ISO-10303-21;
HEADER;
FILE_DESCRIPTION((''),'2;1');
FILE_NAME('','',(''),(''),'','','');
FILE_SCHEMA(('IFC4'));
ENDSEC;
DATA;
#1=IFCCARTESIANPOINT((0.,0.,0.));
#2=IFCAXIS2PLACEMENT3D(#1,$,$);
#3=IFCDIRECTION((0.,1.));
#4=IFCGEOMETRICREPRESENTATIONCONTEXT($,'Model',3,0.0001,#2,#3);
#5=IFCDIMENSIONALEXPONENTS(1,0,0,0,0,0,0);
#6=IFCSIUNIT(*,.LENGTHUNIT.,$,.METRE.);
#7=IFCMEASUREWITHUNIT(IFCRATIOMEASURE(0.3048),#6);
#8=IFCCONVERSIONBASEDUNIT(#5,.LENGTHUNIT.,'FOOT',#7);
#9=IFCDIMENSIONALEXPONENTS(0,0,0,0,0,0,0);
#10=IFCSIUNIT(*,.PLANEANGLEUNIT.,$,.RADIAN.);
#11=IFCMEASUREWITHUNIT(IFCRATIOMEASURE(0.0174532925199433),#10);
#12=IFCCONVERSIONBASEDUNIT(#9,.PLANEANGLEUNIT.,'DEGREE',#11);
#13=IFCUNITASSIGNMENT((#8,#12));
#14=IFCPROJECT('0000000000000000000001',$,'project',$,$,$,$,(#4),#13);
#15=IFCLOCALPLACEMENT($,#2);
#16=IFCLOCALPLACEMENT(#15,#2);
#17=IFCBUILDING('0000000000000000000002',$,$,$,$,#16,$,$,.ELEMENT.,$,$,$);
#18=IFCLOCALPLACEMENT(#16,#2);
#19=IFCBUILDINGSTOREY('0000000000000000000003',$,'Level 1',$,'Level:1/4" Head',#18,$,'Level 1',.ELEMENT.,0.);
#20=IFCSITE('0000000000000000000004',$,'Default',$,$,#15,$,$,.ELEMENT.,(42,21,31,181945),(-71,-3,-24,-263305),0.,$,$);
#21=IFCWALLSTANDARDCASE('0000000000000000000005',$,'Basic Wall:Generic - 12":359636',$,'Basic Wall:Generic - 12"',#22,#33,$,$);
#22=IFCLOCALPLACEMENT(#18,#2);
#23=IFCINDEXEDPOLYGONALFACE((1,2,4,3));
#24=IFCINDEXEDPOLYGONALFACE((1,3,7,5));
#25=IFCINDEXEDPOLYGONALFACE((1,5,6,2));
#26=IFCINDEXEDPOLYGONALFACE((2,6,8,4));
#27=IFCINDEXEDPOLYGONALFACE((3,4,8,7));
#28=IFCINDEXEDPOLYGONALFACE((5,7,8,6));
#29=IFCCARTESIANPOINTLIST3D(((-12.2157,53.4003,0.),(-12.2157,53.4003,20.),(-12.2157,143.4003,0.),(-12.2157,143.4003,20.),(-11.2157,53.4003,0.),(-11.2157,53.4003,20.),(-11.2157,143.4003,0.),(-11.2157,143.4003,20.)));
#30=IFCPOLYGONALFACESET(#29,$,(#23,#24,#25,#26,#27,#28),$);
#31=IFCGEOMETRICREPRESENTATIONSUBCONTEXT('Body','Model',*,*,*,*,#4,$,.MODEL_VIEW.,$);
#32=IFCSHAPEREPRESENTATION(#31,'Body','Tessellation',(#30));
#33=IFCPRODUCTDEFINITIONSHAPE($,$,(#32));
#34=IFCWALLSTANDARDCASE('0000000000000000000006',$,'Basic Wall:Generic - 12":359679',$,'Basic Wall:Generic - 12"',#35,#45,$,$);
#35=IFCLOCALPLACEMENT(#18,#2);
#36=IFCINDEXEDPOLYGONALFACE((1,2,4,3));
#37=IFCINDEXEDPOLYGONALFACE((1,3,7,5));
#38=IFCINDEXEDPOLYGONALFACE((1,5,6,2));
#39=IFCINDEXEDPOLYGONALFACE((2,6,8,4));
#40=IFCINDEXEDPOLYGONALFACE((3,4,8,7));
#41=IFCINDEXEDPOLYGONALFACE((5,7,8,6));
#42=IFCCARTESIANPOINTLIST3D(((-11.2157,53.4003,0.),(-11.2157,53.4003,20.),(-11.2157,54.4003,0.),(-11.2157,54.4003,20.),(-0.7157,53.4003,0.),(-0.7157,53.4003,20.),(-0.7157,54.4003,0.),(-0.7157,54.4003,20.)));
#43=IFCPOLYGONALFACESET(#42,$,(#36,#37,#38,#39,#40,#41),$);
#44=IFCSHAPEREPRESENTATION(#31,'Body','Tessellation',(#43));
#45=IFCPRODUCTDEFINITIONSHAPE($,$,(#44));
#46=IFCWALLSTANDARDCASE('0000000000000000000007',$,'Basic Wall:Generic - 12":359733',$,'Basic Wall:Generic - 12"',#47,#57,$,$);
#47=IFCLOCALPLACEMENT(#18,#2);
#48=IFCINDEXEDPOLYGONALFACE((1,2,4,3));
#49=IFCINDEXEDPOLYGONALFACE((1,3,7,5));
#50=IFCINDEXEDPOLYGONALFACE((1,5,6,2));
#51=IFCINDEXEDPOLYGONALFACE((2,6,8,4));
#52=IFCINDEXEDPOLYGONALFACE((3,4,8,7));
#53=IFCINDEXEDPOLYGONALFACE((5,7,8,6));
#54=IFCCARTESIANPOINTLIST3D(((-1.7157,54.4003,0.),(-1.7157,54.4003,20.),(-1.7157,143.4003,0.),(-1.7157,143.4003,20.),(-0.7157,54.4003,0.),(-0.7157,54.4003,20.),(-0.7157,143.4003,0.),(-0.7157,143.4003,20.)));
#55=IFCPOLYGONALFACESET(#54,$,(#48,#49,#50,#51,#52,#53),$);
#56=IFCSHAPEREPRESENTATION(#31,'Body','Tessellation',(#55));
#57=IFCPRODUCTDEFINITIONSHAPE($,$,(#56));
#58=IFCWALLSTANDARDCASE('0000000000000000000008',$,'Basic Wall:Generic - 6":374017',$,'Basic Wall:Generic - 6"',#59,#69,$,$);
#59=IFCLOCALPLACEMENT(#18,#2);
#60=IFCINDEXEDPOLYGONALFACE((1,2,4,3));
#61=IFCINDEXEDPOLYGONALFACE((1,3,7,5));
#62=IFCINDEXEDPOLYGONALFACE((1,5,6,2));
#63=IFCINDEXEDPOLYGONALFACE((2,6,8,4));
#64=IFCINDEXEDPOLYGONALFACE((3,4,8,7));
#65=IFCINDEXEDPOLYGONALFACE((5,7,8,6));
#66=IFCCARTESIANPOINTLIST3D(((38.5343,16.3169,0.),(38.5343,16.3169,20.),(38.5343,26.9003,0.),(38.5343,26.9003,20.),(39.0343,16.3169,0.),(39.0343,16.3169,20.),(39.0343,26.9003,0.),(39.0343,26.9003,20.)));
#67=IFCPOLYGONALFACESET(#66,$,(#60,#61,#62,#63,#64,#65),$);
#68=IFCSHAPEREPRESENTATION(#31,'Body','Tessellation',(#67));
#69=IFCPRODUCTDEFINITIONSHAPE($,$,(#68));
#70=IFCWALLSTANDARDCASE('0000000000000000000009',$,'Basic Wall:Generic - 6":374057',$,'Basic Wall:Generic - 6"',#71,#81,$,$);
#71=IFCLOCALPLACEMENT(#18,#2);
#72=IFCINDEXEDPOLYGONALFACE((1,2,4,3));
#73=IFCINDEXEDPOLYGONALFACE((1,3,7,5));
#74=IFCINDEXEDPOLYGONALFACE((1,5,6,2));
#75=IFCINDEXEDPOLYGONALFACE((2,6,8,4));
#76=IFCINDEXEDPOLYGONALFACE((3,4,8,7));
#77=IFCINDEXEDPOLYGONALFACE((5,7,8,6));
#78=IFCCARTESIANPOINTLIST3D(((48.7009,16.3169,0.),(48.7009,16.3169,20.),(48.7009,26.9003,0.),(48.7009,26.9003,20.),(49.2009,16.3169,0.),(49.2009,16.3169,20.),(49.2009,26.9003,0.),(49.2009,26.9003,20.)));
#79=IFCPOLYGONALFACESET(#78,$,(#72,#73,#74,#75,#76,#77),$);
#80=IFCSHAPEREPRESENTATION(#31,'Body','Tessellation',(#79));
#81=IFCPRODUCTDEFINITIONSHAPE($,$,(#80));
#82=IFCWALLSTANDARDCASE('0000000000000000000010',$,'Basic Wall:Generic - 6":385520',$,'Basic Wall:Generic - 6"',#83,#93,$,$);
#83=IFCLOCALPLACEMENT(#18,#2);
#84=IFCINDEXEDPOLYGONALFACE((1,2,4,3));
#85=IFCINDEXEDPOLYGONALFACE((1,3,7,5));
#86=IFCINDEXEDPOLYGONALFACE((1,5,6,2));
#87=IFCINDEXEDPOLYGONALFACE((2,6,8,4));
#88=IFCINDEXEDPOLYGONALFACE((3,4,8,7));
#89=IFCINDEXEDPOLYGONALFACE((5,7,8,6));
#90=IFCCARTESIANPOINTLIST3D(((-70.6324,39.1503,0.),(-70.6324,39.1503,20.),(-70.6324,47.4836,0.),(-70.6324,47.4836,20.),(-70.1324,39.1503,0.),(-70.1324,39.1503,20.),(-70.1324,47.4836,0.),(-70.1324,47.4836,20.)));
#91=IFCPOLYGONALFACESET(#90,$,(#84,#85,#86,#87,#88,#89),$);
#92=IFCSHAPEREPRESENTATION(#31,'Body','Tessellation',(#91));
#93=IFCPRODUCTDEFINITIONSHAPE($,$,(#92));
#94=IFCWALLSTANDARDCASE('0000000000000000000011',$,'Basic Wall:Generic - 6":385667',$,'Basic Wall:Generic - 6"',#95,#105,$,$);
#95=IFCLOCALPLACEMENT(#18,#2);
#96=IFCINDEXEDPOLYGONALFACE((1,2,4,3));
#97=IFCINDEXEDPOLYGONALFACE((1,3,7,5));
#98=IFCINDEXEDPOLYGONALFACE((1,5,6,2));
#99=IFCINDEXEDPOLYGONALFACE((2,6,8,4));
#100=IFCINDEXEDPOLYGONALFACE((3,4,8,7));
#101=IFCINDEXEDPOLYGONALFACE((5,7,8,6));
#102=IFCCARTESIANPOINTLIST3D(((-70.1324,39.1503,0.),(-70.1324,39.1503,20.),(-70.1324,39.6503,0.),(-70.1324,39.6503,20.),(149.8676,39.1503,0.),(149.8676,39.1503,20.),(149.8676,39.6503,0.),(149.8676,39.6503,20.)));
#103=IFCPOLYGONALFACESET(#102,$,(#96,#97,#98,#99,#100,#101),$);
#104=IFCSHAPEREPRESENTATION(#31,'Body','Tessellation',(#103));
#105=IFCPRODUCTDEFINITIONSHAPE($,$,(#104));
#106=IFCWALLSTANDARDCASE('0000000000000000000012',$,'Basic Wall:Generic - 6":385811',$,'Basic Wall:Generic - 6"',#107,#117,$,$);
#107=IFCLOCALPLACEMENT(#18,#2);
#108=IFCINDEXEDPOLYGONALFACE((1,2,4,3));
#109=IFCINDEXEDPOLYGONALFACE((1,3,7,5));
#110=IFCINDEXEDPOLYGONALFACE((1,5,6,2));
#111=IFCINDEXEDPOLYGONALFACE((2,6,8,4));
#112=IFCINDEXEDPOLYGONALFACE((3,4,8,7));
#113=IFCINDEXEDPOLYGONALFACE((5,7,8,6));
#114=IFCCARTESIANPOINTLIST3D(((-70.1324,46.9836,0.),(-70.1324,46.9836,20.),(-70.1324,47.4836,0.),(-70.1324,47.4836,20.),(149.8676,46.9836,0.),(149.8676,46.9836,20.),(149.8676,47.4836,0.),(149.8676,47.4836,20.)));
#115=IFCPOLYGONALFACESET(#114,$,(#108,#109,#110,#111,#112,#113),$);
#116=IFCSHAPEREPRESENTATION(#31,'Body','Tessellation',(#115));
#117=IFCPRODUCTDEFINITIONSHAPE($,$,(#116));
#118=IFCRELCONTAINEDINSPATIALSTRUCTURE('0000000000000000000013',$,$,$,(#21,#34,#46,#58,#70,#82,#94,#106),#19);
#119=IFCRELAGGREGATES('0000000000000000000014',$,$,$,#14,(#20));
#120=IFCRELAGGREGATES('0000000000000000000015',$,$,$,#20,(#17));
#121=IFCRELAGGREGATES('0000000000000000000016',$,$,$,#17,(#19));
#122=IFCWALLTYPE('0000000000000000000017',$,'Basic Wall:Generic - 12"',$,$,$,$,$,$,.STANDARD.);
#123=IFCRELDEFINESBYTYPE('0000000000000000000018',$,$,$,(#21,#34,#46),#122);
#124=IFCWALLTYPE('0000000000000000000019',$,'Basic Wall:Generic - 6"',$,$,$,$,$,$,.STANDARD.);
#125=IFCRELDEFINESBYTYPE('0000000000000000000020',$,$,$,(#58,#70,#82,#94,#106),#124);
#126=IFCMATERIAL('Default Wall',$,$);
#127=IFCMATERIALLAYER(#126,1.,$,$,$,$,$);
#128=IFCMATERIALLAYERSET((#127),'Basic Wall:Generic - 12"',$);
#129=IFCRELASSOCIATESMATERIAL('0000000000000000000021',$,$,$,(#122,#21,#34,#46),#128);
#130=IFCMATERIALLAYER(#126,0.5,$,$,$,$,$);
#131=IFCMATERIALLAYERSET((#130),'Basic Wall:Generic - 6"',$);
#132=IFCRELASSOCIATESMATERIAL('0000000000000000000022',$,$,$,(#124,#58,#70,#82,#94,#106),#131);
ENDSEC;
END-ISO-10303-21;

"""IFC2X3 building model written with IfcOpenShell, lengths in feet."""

from ifc_helpers import new_model, entity, si_unit, converted_unit, direction, frame, frame_2d, origin, place, context, subcontext, project, spatial, rectangle, extrude, material, layer, layer_set, layer_usage, type_object, element, save


model = new_model("IFC2X3")

# Units and contexts
model_context = context("Model", 3, precision=0.0001, world=origin(), true_north=direction((0.0, 1.0)))
body_context = subcontext(model_context, "Body", "Model", "MODEL_VIEW")
ifc_project = project(units=[converted_unit("LENGTHUNIT", "FOOT", entity("IfcRatioMeasure", 0.3048), si_unit("LENGTHUNIT", "METRE"), dimensions=[1, 0, 0, 0, 0, 0, 0]), converted_unit("PLANEANGLEUNIT", "DEGREE", entity("IfcRatioMeasure", 0.0174532925199433), si_unit("PLANEANGLEUNIT", "RADIAN"), dimensions=[0, 0, 0, 0, 0, 0, 0])], contexts=[model_context])

# Site, building, storey
site_placement = place(None, origin())
site = spatial("IfcSite", under=ifc_project, at=site_placement, Name="Default", CompositionType="ELEMENT", RefLatitude=(42, 21, 31, 181945), RefLongitude=(-71, -3, -24, -263305), RefElevation=0.0)
building_placement = place(site_placement, origin())
building = spatial("IfcBuilding", under=site, at=building_placement, CompositionType="ELEMENT")
storey_placement = place(building_placement, origin())
storey = spatial("IfcBuildingStorey", under=building, at=storey_placement, Name="Level 1", ObjectType="Level:1/4\" Head", LongName="Level 1", CompositionType="ELEMENT", Elevation=0.0)

# Walls
ifc_material = material(Name="Default Wall")
ifc_layer_1 = layer(ifc_material, 1.0)
ifc_layer_set_1 = layer_set([ifc_layer_1], Name="Basic Wall:Generic - 12\"")
wall_type_1 = type_object("IfcWallType", Name="Basic Wall:Generic - 12\"", PredefinedType="STANDARD", material=ifc_layer_set_1)
ifc_layer_usage_1 = layer_usage(ifc_layer_set_1, "AXIS2", "NEGATIVE", 0.5)
wall_1_placement = place(storey_placement, frame((-11.7157, 143.4003, 0.0), z_axis=(0.0, 0.0, 1.0), x_axis=(0.0, -1.0, 0.0)))
element("IfcWallStandardCase", 1, at=wall_1_placement, inside=storey, type_object=wall_type_1, material=ifc_layer_usage_1, Name="Basic Wall:Generic - 12\":359636", ObjectType="Basic Wall:Generic - 12\"", context=body_context, shape_type="SweptSolid", body=[
    extrude(rectangle(XDim=90.0, YDim=1.0, at=frame_2d((45.0, 0.0), x_axis=(-1.0, 0.0))), origin(), (0.0, 0.0, 1.0), 20.0),
])
ifc_layer_usage_2 = layer_usage(ifc_layer_set_1, "AXIS2", "NEGATIVE", 0.5)
wall_2_placement = place(storey_placement, frame((-11.2157, 53.9003, 0.0)))
element("IfcWallStandardCase", 2, at=wall_2_placement, inside=storey, type_object=wall_type_1, material=ifc_layer_usage_2, Name="Basic Wall:Generic - 12\":359679", ObjectType="Basic Wall:Generic - 12\"", context=body_context, shape_type="SweptSolid", body=[
    extrude(rectangle(XDim=10.5, YDim=1.0, at=frame_2d((5.25, 0.0), x_axis=(-1.0, 0.0))), origin(), (0.0, 0.0, 1.0), 20.0),
])
ifc_layer_usage_3 = layer_usage(ifc_layer_set_1, "AXIS2", "NEGATIVE", 0.5)
wall_3_placement = place(storey_placement, frame((-1.2157, 54.4003, 0.0), z_axis=(0.0, 0.0, 1.0), x_axis=(0.0, 1.0, 0.0)))
element("IfcWallStandardCase", 3, at=wall_3_placement, inside=storey, type_object=wall_type_1, material=ifc_layer_usage_3, Name="Basic Wall:Generic - 12\":359733", ObjectType="Basic Wall:Generic - 12\"", context=body_context, shape_type="SweptSolid", body=[
    extrude(rectangle(XDim=89.0, YDim=1.0, at=frame_2d((44.5, 0.0), x_axis=(-1.0, 0.0))), origin(), (0.0, 0.0, 1.0), 20.0),
])
ifc_layer_2 = layer(ifc_material, 0.5)
ifc_layer_set_2 = layer_set([ifc_layer_2], Name="Basic Wall:Generic - 6\"")
ifc_layer_usage_4 = layer_usage(ifc_layer_set_2, "AXIS2", "NEGATIVE", 0.25)
wall_type_2 = type_object("IfcWallType", Name="Basic Wall:Generic - 6\"", PredefinedType="STANDARD", material=ifc_layer_set_2)
wall_4_placement = place(storey_placement, frame((38.7843, 26.9003, 0.0), z_axis=(0.0, 0.0, 1.0), x_axis=(0.0, -1.0, 0.0)))
element("IfcWallStandardCase", 4, at=wall_4_placement, inside=storey, type_object=wall_type_2, material=ifc_layer_usage_4, Name="Basic Wall:Generic - 6\":374017", ObjectType="Basic Wall:Generic - 6\"", context=body_context, shape_type="SweptSolid", body=[
    extrude(rectangle(XDim=10.5833, YDim=0.5, at=frame_2d((5.2917, 0.0), x_axis=(-1.0, 0.0))), origin(), (0.0, 0.0, 1.0), 20.0),
])
ifc_layer_usage_5 = layer_usage(ifc_layer_set_2, "AXIS2", "NEGATIVE", 0.25)
wall_5_placement = place(storey_placement, frame((48.9509, 26.9003, 0.0), z_axis=(0.0, 0.0, 1.0), x_axis=(0.0, -1.0, 0.0)))
element("IfcWallStandardCase", 5, at=wall_5_placement, inside=storey, type_object=wall_type_2, material=ifc_layer_usage_5, Name="Basic Wall:Generic - 6\":374057", ObjectType="Basic Wall:Generic - 6\"", context=body_context, shape_type="SweptSolid", body=[
    extrude(rectangle(XDim=10.5833, YDim=0.5, at=frame_2d((5.2917, 0.0), x_axis=(-1.0, 0.0))), origin(), (0.0, 0.0, 1.0), 20.0),
])
ifc_layer_usage_6 = layer_usage(ifc_layer_set_2, "AXIS2", "NEGATIVE", 0.25)
wall_6_placement = place(storey_placement, frame((-70.3824, 47.4836, 0.0), z_axis=(0.0, 0.0, 1.0), x_axis=(0.0, -1.0, 0.0)))
element("IfcWallStandardCase", 6, at=wall_6_placement, inside=storey, type_object=wall_type_2, material=ifc_layer_usage_6, Name="Basic Wall:Generic - 6\":385520", ObjectType="Basic Wall:Generic - 6\"", context=body_context, shape_type="SweptSolid", body=[
    extrude(rectangle(XDim=8.3333, YDim=0.5, at=frame_2d((4.1667, 0.0), x_axis=(-1.0, 0.0))), origin(), (0.0, 0.0, 1.0), 20.0),
])
ifc_layer_usage_7 = layer_usage(ifc_layer_set_2, "AXIS2", "NEGATIVE", 0.25)
wall_7_placement = place(storey_placement, frame((-70.1324, 39.4003, 0.0)))
element("IfcWallStandardCase", 7, at=wall_7_placement, inside=storey, type_object=wall_type_2, material=ifc_layer_usage_7, Name="Basic Wall:Generic - 6\":385667", ObjectType="Basic Wall:Generic - 6\"", context=body_context, shape_type="SweptSolid", body=[
    extrude(rectangle(XDim=220.0, YDim=0.5, at=frame_2d((110.0, 0.0), x_axis=(-1.0, 0.0))), origin(), (0.0, 0.0, 1.0), 20.0),
])
ifc_layer_usage_8 = layer_usage(ifc_layer_set_2, "AXIS2", "NEGATIVE", 0.25)
wall_8_placement = place(storey_placement, frame((-70.1324, 47.2336, 0.0)))
element("IfcWallStandardCase", 8, at=wall_8_placement, inside=storey, type_object=wall_type_2, material=ifc_layer_usage_8, Name="Basic Wall:Generic - 6\":385811", ObjectType="Basic Wall:Generic - 6\"", context=body_context, shape_type="SweptSolid", body=[
    extrude(rectangle(XDim=220.0, YDim=0.5, at=frame_2d((110.0, 0.0), x_axis=(-1.0, 0.0))), origin(), (0.0, 0.0, 1.0), 20.0),
])

save(model, "model.ifc")
